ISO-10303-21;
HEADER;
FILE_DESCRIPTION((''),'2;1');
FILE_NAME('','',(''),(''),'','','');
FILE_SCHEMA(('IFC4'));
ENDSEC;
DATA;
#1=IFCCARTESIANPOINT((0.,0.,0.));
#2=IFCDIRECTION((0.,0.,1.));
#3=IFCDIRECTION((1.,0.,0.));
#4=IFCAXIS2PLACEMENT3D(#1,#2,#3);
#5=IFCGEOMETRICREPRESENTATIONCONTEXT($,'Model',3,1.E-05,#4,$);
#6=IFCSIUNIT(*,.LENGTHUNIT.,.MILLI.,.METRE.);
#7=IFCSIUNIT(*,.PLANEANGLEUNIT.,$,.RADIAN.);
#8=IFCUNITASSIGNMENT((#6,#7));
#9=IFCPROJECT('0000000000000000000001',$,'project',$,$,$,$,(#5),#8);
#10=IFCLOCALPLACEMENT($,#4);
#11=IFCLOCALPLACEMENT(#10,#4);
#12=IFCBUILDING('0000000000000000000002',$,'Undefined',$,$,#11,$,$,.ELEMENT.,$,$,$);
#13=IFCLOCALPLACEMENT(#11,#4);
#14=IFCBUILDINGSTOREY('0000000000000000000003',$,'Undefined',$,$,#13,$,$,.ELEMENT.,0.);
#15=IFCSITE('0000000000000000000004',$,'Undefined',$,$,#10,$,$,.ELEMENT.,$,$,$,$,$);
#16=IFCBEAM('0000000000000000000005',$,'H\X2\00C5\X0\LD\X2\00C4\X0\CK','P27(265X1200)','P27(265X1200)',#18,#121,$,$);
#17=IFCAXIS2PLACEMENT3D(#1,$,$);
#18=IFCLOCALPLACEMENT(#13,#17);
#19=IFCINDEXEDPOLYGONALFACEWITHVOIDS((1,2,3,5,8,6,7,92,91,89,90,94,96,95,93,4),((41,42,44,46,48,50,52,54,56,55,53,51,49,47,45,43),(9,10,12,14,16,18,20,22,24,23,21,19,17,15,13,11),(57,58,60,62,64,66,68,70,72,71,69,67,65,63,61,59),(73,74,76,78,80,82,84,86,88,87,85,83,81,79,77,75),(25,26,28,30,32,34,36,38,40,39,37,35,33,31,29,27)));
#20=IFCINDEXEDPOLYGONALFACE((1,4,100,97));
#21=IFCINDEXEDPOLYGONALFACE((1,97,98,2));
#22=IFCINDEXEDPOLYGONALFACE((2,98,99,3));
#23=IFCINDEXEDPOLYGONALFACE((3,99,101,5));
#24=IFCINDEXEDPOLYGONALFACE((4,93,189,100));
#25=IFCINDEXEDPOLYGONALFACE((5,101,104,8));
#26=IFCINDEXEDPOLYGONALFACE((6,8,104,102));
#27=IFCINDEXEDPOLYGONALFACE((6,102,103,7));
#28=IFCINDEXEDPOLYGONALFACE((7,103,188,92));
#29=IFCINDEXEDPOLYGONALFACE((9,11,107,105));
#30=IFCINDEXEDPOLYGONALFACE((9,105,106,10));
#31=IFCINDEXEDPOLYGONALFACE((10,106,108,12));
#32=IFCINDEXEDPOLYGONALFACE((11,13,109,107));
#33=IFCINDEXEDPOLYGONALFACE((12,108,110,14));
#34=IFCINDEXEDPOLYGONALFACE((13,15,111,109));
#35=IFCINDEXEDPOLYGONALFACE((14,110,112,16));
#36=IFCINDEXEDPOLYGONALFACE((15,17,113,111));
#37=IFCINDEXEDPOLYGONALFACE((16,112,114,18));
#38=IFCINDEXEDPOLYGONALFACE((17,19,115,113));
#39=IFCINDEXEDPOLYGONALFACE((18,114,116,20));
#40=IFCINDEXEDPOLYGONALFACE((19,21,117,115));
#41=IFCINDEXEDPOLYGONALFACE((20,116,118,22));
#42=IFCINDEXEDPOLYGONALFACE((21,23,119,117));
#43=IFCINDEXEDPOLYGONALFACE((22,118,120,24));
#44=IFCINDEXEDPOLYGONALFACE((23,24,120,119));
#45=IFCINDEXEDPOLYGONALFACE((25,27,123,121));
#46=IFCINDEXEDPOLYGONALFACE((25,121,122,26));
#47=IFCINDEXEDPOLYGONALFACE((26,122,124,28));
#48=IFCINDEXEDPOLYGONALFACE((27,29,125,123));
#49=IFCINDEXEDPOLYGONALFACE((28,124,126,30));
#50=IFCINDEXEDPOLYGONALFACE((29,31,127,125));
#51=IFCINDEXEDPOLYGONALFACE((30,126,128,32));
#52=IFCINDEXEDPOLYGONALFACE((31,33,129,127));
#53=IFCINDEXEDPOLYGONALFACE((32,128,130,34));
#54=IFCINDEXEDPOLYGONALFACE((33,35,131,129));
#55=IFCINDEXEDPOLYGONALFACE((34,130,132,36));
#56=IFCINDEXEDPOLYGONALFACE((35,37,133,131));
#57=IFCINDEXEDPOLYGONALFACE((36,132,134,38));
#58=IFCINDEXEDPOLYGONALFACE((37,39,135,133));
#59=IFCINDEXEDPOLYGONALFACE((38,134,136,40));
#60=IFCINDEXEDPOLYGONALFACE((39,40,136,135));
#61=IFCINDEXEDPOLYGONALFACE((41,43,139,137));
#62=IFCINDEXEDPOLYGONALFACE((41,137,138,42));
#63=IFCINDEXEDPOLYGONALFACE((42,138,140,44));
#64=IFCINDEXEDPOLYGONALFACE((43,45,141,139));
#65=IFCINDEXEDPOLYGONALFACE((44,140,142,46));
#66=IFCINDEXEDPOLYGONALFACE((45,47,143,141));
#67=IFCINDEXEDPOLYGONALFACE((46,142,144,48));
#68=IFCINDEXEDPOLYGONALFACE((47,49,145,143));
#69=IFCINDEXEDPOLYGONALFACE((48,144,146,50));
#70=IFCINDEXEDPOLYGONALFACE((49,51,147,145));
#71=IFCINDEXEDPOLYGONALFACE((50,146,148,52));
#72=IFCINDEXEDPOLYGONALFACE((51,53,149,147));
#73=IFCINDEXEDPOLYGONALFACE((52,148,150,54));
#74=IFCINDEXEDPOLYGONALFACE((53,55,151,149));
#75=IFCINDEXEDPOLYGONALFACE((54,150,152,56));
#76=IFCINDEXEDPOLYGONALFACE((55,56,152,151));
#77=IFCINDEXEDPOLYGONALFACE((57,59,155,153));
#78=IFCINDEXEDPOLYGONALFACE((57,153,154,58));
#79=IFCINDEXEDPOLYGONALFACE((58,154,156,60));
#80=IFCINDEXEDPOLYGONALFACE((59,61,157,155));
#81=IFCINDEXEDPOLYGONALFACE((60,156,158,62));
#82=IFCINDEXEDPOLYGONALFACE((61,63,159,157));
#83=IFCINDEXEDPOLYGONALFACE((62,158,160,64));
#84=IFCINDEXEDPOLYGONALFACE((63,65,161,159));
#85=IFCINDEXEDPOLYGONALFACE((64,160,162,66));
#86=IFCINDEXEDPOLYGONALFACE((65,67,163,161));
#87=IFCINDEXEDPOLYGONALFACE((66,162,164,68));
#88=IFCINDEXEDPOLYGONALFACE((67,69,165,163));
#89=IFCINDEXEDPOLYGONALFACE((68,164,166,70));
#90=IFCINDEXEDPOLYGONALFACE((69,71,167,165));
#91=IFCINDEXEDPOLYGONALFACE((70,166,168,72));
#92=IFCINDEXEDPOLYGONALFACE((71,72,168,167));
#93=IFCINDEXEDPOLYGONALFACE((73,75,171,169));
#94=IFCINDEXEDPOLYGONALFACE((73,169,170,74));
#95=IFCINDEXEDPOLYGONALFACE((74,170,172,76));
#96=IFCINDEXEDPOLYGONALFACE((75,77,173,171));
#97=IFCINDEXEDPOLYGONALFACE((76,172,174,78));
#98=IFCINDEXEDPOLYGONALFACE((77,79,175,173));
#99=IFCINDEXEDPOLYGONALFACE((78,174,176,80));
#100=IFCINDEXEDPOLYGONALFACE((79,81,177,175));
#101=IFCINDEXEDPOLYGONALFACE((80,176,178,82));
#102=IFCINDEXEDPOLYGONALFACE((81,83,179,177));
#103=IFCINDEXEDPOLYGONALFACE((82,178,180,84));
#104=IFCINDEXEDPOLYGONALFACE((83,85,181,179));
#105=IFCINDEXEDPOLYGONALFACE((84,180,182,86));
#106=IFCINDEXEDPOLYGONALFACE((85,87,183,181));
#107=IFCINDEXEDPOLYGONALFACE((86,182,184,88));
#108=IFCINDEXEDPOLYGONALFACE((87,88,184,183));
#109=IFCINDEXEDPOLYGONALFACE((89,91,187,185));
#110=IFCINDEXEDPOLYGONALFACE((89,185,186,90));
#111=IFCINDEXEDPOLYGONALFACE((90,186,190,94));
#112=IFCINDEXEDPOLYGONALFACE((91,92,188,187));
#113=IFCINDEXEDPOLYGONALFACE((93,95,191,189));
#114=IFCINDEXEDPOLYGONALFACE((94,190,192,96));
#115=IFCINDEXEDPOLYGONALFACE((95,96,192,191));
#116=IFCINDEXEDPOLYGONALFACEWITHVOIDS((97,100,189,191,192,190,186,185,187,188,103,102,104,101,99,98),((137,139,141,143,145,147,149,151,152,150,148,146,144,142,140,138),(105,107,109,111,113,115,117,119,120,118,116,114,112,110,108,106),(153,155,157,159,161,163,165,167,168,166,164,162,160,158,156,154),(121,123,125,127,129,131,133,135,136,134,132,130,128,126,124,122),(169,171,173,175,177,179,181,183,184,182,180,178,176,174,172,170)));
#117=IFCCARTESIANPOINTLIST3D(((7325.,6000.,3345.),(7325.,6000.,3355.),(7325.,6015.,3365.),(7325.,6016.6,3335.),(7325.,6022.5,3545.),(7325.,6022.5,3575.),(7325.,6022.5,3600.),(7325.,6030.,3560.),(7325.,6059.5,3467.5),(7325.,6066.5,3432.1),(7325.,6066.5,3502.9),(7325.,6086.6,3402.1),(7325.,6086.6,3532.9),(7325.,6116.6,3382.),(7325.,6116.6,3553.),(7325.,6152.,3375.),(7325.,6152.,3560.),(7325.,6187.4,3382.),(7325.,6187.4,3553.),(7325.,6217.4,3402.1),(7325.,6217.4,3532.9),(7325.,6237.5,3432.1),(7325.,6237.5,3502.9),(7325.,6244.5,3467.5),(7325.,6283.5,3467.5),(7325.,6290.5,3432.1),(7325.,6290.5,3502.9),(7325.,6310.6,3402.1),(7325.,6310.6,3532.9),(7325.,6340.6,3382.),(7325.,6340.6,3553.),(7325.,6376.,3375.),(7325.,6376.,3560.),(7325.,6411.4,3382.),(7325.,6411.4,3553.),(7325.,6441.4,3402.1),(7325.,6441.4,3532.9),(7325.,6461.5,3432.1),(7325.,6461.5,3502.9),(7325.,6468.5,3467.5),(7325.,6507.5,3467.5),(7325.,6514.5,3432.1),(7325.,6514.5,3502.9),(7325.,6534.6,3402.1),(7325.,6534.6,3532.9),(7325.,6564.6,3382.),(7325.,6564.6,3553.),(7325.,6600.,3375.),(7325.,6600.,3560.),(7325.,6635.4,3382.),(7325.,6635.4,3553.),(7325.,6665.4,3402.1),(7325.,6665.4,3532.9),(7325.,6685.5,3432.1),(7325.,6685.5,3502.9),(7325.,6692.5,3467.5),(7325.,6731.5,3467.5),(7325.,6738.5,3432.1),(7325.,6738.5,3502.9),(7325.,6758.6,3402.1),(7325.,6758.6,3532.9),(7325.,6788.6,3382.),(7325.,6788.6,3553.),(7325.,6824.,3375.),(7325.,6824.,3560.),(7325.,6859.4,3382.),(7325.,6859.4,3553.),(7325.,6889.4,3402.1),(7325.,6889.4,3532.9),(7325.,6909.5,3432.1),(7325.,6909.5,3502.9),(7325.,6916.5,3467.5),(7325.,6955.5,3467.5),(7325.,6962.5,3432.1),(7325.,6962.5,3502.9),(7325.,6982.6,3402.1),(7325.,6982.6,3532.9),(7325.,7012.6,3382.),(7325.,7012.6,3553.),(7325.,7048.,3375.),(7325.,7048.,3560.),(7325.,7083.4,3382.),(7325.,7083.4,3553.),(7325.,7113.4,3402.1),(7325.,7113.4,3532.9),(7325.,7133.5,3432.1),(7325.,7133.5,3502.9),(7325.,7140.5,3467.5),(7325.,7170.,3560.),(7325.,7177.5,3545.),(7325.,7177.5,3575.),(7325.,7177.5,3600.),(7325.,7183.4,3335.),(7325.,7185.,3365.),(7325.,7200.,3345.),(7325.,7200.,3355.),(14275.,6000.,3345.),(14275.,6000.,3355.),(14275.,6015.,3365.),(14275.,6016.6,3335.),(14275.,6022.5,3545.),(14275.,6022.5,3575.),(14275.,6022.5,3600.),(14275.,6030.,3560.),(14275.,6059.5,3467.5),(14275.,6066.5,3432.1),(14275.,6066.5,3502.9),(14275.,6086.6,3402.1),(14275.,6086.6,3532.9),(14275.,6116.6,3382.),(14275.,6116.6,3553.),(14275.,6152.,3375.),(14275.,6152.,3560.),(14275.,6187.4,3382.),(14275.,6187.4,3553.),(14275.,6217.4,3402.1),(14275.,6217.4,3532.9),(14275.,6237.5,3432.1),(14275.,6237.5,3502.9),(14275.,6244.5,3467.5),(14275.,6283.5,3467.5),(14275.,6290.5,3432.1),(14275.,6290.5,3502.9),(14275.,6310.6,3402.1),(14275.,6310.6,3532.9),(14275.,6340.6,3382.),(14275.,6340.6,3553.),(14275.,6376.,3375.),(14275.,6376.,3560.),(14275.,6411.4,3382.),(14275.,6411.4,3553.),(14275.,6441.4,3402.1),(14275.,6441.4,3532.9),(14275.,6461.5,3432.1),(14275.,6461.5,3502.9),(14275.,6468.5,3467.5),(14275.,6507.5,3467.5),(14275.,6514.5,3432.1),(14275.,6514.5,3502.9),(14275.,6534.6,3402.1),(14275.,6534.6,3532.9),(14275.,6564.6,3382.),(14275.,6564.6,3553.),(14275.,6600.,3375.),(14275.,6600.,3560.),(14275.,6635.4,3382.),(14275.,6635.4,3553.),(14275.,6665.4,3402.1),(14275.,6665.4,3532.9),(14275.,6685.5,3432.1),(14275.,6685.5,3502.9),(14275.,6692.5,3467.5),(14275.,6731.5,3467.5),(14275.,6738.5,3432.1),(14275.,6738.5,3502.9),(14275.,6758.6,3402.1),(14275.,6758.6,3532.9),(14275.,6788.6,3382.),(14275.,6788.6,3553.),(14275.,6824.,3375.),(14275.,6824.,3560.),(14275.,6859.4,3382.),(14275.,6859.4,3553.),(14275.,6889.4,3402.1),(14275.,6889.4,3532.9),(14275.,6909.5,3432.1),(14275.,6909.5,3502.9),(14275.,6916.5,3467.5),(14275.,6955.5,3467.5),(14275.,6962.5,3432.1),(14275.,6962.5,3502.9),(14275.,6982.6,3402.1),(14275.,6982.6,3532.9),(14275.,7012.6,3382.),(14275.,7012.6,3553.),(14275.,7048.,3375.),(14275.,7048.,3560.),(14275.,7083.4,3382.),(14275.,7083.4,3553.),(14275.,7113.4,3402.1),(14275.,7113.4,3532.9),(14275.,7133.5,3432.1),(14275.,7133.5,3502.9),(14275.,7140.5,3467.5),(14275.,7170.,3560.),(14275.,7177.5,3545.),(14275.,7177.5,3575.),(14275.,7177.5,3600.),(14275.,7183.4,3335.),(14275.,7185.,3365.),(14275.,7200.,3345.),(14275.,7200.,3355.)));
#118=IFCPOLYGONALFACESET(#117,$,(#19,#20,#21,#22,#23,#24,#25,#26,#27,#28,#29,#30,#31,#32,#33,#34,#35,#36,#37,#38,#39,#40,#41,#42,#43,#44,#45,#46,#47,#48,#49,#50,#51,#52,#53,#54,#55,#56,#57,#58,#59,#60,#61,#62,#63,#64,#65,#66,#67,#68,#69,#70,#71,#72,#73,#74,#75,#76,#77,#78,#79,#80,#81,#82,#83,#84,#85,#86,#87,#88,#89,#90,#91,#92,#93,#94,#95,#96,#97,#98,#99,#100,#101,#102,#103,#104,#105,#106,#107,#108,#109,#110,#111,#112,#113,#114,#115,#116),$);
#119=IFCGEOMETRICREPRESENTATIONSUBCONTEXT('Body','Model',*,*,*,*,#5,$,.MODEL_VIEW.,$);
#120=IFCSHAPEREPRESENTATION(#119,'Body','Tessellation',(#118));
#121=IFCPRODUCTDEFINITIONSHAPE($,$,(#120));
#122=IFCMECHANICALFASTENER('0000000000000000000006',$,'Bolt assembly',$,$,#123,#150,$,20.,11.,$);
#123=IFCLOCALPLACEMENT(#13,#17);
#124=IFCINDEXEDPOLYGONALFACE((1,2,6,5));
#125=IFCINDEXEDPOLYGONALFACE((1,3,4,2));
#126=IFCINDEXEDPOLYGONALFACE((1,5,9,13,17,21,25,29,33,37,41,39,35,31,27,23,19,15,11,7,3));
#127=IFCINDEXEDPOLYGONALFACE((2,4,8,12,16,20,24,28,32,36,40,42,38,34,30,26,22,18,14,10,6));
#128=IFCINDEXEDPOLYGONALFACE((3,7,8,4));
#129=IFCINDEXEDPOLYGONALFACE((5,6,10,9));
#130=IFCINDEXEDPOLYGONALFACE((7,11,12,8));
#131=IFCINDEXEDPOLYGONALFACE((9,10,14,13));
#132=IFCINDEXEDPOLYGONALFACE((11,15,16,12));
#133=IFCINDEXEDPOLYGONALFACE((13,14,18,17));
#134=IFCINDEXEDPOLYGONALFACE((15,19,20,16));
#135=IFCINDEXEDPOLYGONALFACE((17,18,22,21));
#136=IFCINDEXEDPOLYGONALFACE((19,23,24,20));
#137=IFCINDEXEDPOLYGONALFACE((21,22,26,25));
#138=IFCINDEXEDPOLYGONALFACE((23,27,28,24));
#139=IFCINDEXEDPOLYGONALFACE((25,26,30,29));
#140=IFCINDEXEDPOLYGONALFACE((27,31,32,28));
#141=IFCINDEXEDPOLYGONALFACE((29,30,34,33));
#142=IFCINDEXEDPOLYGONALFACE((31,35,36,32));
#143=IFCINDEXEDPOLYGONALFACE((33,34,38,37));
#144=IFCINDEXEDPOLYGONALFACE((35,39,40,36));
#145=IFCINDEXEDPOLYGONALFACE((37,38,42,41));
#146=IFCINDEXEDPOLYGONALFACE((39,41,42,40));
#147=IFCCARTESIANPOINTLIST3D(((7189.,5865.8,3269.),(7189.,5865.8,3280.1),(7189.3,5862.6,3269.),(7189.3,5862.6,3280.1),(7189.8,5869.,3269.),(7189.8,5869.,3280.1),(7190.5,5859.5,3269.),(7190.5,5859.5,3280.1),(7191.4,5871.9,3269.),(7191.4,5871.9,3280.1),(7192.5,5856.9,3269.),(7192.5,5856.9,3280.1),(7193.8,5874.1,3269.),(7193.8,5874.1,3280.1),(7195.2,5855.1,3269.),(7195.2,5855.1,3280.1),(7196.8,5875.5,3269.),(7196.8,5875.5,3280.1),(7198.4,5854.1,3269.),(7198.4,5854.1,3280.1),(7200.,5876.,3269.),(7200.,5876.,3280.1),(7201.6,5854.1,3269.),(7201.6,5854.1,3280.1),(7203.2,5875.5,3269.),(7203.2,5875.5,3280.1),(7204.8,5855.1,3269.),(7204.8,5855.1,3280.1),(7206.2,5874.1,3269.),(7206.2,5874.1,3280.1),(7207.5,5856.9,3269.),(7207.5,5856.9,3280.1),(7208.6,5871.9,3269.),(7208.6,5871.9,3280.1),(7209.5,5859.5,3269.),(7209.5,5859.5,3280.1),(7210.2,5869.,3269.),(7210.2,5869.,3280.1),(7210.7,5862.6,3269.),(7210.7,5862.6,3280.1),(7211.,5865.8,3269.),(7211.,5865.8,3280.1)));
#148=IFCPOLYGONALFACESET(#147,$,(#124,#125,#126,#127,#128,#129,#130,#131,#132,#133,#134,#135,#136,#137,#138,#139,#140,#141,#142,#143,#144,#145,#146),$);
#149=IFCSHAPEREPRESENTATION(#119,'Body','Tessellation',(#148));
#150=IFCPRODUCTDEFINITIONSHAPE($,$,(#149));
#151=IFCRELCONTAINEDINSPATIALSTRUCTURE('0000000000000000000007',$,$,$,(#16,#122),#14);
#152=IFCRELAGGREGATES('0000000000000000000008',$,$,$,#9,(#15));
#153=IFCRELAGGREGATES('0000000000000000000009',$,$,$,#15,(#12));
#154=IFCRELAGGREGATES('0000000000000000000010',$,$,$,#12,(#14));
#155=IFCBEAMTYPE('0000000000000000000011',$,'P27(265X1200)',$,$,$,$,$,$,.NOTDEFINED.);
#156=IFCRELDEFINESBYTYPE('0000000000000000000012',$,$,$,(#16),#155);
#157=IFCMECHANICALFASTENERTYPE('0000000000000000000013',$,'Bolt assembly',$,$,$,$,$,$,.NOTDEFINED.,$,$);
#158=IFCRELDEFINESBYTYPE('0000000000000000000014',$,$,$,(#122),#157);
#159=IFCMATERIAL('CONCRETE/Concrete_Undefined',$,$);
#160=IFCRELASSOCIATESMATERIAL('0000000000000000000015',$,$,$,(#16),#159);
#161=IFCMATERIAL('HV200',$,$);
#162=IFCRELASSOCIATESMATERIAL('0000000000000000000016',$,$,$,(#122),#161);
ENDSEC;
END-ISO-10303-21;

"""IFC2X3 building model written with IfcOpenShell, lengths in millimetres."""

from ifc_helpers import new_model, si_unit, frame, origin_with_axes, origin_2d_with_axis, place, context, subcontext, project, spatial, polyline, circle, outline, extrude, source, transform, mapped, material, type_object, element, save


model = new_model("IFC2X3")

# Units and contexts
model_context = context("Model", 3, precision=1e-05, world=origin_with_axes())
body_context = subcontext(model_context, "Body", "Model", "MODEL_VIEW")
ifc_project = project(units=[si_unit("LENGTHUNIT", "METRE", prefix="MILLI"), si_unit("PLANEANGLEUNIT", "RADIAN")], contexts=[model_context])

# Site, building, storey
site_placement = place(None, origin_with_axes())
site = spatial("IfcSite", under=ifc_project, at=site_placement, Name="Undefined", CompositionType="ELEMENT")
building_placement = place(site_placement, origin_with_axes())
building = spatial("IfcBuilding", under=site, at=building_placement, Name="Undefined", CompositionType="ELEMENT")
storey_placement = place(building_placement, origin_with_axes())
storey = spatial("IfcBuildingStorey", under=building, at=storey_placement, Name="Undefined", CompositionType="ELEMENT", Elevation=0.0)

# Beam
ifc_material_1 = material(Name="CONCRETE/Concrete_Undefined")
beam_type_1 = type_object("IfcBeamType", Name="P27(265X1200)", PredefinedType="NOTDEFINED")
beam_1_placement = place(storey_placement, frame((7325.0, 6600.0, 3467.5), z_axis=(0.0, 0.0, 1.0), x_axis=(1.0, 0.0, 0.0)))
element("IfcBeam", 1, at=beam_1_placement, inside=storey, type_object=beam_type_1, material=ifc_material_1, Name="HÅLDÄCK", Description="P27(265X1200)", ObjectType="P27(265X1200)", context=body_context, shape_type="SweptSolid", body=[
    extrude(outline(polyline([(-583.4, -132.5), (-600.0, -122.5), (-600.0, -112.5), (-585.0, -102.5), (-577.5, 77.5), (-570.0, 92.5), (-577.5, 107.5), (-577.5, 132.5), (577.5, 132.5), (577.5, 107.5), (570.0, 92.5), (577.5, 77.5), (585.0, -102.5), (600.0, -112.5), (600.0, -122.5), (583.4, -132.5), (-583.4, -132.5)]), holes=[polyline([(-513.4, 65.4), (-533.5, 35.4), (-540.5, 0.0), (-533.5, -35.4), (-513.4, -65.4), (-483.4, -85.5), (-448.0, -92.5), (-412.6, -85.5), (-382.6, -65.4), (-362.5, -35.4), (-355.5, 0.0), (-362.5, 35.4), (-382.6, 65.4), (-412.6, 85.5), (-448.0, 92.5), (-483.4, 85.5), (-513.4, 65.4)]), polyline([(-289.4, 65.4), (-309.5, 35.4), (-316.5, 0.0), (-309.5, -35.4), (-289.4, -65.4), (-259.4, -85.5), (-224.0, -92.5), (-188.6, -85.5), (-158.6, -65.4), (-138.5, -35.4), (-131.5, 0.0), (-138.5, 35.4), (-158.6, 65.4), (-188.6, 85.5), (-224.0, 92.5), (-259.4, 85.5), (-289.4, 65.4)]), polyline([(-65.4, 65.4), (-85.5, 35.4), (-92.5, 0.0), (-85.5, -35.4), (-65.4, -65.4), (-35.4, -85.5), (0.0, -92.5), (35.4, -85.5), (65.4, -65.4), (85.5, -35.4), (92.5, 0.0), (85.5, 35.4), (65.4, 65.4), (35.4, 85.5), (0.0, 92.5), (-35.4, 85.5), (-65.4, 65.4)]), polyline([(158.6, 65.4), (138.5, 35.4), (131.5, 0.0), (138.5, -35.4), (158.6, -65.4), (188.6, -85.5), (224.0, -92.5), (259.4, -85.5), (289.4, -65.4), (309.5, -35.4), (316.5, 0.0), (309.5, 35.4), (289.4, 65.4), (259.4, 85.5), (224.0, 92.5), (188.6, 85.5), (158.6, 65.4)]), polyline([(382.6, 65.4), (362.5, 35.4), (355.5, 0.0), (362.5, -35.4), (382.6, -65.4), (412.6, -85.5), (448.0, -92.5), (483.4, -85.5), (513.4, -65.4), (533.5, -35.4), (540.5, 0.0), (533.5, 35.4), (513.4, 65.4), (483.4, 85.5), (448.0, 92.5), (412.6, 85.5), (382.6, 65.4)])]), frame((6950.0, 0.0, 0.0), z_axis=(-1.0, 0.0, 0.0), x_axis=(0.0, -1.0, 0.0)), (0.0, 0.0, 1.0), 6950.0),
])

# Mechanical fastener
ifc_material_2 = material(Name="HV200")
mechanical_fastener_type = type_object("IfcMechanicalFastenerType", Name="Bolt assembly")
shared_shape_1 = source(origin_with_axes(), body_context, "Body", "SweptSolid", [
    extrude(circle(Radius=11.0, at=origin_2d_with_axis()), frame((0.0, -11.0, 0.0), z_axis=(0.0, 1.0, 0.0), x_axis=(1.0, 0.0, 0.0)), (0.0, 0.0, 1.0), 11.1),
])
mechanical_fastener_1_placement = place(storey_placement, frame((7200.0, 5865.0, 3280.0), z_axis=(1.0, 0.0, 0.0), x_axis=(0.0, 1.0, 0.0)))
element("IfcMechanicalFastener", 2, at=mechanical_fastener_1_placement, inside=storey, type_object=mechanical_fastener_type, material=ifc_material_2, Name="Bolt assembly", NominalDiameter=20.0, NominalLength=11.0, context=body_context, shape_type="MappedRepresentation", body=[
    mapped(shared_shape_1, transform((0.0, 0.0, 0.0))),
])

save(model, "model.ifc")
